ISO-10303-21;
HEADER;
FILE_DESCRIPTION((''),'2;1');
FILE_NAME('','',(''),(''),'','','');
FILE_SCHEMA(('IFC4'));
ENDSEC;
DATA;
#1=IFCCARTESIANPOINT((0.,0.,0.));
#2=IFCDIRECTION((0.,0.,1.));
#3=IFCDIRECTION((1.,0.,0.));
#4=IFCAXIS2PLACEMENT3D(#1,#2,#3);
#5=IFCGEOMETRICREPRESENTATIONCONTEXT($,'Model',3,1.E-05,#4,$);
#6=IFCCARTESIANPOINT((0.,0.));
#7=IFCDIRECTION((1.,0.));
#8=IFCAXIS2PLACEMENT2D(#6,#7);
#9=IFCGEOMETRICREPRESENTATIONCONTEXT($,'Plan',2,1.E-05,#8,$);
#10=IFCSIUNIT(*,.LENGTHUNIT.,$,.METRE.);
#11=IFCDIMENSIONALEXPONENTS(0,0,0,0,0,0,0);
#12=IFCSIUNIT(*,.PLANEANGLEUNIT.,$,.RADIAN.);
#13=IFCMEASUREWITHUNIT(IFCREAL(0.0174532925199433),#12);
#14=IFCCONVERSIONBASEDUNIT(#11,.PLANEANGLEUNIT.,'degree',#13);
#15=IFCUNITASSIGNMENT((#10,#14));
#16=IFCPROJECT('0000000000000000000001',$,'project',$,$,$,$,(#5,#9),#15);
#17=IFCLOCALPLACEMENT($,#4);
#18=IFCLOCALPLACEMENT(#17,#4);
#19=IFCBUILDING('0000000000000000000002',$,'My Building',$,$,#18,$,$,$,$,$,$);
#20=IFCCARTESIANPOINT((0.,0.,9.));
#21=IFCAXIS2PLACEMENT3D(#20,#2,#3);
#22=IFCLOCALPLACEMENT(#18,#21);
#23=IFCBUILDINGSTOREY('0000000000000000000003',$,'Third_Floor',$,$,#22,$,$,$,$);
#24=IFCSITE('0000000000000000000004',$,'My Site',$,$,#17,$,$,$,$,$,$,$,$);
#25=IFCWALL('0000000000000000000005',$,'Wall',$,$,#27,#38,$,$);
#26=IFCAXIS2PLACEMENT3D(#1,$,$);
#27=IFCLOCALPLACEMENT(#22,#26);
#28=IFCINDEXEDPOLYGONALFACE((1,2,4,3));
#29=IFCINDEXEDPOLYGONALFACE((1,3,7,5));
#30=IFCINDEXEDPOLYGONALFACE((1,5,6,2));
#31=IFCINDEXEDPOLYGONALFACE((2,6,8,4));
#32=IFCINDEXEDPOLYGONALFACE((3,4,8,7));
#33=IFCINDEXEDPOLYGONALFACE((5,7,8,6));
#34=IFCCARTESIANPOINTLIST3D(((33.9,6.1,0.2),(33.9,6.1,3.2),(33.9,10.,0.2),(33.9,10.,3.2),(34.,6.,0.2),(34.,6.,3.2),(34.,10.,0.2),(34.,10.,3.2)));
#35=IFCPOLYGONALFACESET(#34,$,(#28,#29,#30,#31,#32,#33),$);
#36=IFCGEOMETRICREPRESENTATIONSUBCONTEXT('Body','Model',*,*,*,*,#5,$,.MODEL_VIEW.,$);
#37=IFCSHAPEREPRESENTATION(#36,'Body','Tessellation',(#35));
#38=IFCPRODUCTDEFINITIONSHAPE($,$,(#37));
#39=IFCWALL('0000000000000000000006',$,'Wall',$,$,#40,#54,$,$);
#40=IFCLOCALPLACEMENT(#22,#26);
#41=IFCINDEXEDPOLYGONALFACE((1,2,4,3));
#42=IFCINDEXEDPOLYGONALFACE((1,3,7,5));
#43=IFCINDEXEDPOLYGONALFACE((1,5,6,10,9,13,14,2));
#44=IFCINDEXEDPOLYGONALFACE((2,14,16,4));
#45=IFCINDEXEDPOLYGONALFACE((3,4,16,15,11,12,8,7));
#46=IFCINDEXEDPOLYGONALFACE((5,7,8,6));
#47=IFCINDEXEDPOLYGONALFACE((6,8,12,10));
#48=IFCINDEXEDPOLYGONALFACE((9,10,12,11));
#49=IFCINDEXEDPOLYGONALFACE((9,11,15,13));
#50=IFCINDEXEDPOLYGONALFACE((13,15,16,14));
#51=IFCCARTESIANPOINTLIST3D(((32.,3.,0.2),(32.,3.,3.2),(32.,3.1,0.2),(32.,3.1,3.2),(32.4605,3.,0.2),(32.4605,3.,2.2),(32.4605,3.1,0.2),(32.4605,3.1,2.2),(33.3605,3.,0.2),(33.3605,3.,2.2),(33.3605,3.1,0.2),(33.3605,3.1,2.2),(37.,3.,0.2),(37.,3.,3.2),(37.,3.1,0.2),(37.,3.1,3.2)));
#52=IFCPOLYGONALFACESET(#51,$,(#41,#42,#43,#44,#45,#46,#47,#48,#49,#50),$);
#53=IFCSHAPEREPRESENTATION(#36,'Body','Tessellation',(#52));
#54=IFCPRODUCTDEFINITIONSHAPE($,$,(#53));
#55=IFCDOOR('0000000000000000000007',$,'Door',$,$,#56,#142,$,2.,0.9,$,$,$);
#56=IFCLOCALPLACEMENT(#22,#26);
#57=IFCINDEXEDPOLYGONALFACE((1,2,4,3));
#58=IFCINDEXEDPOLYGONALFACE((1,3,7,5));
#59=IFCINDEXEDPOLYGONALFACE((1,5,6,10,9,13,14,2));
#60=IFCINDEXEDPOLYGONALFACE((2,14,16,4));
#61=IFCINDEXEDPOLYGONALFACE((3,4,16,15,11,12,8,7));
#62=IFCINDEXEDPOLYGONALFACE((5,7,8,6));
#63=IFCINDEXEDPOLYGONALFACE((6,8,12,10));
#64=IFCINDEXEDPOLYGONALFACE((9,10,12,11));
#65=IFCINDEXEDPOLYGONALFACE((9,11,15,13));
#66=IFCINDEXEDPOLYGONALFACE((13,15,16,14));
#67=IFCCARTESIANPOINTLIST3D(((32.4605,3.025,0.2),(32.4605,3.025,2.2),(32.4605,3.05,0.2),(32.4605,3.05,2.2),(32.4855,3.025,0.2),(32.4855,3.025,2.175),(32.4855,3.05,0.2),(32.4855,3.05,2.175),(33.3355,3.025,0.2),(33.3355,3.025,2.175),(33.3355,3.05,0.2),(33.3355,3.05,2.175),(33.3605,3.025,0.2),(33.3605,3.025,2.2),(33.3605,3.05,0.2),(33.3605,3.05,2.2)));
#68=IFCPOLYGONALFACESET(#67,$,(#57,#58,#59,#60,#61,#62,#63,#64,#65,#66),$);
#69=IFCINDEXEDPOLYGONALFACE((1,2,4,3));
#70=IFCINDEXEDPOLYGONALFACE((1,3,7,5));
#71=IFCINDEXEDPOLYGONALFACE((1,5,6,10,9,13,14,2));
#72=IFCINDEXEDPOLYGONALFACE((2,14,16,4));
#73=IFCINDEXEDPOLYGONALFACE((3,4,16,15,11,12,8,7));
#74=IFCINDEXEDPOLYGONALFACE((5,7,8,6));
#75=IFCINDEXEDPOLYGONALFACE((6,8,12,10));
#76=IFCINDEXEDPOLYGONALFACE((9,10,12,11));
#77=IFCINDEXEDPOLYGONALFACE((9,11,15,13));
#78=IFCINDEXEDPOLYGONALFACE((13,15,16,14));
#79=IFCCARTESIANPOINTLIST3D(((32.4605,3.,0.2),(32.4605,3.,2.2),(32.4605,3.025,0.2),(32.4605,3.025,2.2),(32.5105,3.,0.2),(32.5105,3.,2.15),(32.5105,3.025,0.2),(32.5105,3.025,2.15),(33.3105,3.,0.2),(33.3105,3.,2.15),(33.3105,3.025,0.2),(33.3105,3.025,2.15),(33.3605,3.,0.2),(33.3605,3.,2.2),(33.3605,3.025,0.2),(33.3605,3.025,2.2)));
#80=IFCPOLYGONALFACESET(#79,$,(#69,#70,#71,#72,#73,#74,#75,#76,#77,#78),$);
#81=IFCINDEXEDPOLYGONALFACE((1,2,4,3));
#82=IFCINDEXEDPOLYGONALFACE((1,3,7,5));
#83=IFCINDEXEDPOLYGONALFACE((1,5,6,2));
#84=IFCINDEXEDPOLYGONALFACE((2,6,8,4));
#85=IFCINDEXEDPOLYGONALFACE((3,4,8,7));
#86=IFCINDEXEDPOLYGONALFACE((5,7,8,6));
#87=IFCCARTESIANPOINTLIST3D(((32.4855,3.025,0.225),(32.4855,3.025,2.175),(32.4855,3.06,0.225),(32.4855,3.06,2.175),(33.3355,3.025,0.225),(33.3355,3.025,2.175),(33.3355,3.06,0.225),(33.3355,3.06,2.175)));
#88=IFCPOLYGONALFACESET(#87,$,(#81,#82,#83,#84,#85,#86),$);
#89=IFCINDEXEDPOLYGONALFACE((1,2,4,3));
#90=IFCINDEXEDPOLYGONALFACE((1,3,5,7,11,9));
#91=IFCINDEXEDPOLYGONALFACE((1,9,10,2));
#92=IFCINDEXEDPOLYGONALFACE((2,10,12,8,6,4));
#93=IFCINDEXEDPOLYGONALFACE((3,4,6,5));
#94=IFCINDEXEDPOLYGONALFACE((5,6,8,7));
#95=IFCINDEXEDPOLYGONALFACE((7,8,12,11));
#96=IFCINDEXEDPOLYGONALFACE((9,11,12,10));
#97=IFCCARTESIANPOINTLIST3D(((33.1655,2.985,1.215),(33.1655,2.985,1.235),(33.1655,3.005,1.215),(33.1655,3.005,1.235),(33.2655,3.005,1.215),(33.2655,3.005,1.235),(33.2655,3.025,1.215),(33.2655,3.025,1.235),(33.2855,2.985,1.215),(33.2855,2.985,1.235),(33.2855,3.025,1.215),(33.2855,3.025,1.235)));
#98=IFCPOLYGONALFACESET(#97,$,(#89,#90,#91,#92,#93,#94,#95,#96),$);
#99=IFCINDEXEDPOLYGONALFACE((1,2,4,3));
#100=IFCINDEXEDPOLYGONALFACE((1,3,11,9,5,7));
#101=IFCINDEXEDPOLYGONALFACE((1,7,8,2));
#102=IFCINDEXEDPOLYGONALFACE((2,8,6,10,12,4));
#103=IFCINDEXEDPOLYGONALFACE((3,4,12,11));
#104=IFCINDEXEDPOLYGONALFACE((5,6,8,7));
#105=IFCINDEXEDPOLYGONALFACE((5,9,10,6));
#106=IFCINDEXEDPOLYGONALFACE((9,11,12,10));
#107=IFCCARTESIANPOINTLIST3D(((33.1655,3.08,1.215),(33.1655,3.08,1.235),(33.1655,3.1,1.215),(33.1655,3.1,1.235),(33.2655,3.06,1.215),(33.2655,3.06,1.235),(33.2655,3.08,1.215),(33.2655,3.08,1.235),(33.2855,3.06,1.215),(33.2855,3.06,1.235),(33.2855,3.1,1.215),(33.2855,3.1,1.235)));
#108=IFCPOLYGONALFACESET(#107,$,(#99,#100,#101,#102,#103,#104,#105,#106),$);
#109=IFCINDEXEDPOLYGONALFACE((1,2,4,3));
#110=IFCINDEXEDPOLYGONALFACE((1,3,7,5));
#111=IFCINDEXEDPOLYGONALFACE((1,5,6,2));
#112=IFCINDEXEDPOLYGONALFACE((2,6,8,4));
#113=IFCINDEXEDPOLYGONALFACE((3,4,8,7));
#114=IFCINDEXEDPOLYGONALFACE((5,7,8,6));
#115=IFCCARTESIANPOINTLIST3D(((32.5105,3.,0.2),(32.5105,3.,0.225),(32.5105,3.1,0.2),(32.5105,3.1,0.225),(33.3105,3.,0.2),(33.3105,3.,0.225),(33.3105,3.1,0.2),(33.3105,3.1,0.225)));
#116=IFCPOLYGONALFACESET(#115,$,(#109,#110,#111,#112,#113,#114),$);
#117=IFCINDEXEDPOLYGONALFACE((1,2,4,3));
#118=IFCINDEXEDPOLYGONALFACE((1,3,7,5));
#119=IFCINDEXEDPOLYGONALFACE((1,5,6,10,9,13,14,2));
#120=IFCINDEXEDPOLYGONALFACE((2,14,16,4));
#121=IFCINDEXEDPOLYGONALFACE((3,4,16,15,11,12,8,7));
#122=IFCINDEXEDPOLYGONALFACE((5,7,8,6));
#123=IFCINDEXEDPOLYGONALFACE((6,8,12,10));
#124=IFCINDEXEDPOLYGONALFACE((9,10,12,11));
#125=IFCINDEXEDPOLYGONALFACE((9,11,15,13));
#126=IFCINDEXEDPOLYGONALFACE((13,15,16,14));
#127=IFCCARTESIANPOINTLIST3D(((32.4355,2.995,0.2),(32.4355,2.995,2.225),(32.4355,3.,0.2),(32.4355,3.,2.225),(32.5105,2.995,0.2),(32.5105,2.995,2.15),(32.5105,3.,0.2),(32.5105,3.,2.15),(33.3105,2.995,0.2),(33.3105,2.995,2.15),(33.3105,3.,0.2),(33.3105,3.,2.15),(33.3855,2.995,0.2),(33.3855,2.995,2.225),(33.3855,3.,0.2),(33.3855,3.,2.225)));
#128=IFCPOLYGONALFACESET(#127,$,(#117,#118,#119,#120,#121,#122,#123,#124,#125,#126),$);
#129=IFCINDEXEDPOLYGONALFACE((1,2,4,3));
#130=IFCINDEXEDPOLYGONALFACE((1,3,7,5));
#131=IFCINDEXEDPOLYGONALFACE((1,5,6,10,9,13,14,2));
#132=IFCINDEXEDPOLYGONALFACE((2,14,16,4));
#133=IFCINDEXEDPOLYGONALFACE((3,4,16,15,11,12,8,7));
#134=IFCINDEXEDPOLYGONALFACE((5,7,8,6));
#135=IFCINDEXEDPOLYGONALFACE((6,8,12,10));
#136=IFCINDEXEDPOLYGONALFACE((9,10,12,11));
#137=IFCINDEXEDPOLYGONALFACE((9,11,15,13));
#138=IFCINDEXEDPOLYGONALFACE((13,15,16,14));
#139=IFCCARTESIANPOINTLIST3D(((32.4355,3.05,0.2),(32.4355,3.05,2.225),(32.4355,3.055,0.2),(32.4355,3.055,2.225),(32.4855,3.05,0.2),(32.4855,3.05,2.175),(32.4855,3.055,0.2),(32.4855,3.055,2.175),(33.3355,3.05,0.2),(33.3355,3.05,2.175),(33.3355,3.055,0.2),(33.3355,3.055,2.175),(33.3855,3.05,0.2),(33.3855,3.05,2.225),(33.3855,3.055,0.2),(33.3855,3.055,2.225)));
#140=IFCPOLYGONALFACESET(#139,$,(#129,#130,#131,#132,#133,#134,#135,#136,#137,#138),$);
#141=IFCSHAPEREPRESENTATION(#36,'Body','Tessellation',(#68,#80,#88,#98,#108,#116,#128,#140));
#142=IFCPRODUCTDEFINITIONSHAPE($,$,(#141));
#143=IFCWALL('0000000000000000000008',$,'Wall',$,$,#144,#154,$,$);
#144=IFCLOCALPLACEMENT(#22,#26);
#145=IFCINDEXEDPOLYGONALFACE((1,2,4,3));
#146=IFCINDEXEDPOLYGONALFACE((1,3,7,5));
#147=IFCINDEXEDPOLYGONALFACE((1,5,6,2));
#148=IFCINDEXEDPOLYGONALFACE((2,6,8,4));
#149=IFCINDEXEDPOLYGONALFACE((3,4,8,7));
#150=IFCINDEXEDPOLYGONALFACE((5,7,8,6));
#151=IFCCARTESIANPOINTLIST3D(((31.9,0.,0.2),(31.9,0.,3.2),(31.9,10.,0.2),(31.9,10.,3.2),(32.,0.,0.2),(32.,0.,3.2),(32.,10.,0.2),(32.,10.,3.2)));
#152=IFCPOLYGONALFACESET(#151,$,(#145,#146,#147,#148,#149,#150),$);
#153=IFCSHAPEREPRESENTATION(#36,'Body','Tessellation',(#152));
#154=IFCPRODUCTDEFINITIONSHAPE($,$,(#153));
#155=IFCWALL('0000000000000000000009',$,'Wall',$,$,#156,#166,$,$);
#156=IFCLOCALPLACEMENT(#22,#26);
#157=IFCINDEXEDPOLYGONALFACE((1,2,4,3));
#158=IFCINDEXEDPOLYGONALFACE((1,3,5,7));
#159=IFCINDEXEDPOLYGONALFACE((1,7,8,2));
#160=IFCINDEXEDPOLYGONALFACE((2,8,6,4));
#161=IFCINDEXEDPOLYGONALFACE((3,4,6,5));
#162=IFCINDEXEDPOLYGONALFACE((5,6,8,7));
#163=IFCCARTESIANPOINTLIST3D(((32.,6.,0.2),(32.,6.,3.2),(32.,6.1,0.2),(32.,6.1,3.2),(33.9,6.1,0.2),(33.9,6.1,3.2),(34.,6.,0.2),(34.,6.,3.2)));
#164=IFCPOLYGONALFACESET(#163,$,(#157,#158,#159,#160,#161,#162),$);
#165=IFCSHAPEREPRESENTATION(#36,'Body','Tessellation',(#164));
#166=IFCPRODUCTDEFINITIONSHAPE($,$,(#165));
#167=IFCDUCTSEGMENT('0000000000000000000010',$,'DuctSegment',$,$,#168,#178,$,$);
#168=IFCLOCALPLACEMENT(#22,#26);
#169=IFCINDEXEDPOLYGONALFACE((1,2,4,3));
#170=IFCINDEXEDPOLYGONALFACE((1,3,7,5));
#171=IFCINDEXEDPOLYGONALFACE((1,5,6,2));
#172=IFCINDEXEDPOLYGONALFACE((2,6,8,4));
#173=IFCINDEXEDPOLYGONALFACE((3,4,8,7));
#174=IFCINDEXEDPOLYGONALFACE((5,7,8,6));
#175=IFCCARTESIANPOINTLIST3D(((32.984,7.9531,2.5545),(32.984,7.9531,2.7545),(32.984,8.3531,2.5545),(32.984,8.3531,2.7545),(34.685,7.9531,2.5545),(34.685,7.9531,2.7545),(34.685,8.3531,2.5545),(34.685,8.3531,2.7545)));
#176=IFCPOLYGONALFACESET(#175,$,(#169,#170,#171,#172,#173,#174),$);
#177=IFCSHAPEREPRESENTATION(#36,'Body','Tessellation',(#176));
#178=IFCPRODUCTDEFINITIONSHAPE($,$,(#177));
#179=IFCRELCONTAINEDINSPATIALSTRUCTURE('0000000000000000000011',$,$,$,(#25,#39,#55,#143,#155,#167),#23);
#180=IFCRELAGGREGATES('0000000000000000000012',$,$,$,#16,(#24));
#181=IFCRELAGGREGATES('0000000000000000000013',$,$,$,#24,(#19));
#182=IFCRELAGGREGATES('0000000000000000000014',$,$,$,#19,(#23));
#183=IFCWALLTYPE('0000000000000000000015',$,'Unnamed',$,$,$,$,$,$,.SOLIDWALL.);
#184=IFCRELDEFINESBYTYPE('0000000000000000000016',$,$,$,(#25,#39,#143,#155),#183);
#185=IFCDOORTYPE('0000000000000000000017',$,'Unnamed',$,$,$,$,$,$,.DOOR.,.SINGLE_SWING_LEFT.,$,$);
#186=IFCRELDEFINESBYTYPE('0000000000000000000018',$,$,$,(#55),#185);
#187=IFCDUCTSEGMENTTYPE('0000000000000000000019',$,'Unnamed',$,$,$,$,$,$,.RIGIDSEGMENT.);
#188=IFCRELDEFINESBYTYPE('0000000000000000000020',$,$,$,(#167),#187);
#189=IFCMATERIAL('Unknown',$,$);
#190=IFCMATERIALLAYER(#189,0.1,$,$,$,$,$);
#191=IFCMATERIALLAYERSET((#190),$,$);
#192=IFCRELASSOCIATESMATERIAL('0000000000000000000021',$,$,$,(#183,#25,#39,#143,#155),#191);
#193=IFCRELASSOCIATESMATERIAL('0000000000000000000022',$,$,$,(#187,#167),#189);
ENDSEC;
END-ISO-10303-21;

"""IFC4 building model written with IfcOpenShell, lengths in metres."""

from ifc_helpers import new_model, entity, si_unit, converted_unit, frame, origin_with_axes, origin_2d_with_axis, place, context, subcontext, project, spatial, line, indexed_curve, rectangle, outline, extrude, shape, source, transform, mapped, material, layer, layer_set, layer_usage, material_profile, profile_set, profile_usage, type_object, type_shapes, element, fill, save


model = new_model("IFC4")

# Units and contexts
model_context = context("Model", 3, precision=1e-05, world=origin_with_axes())
plan_context = context("Plan", 2, precision=1e-05, world=origin_2d_with_axis())
body_context_1 = subcontext(model_context, "Body", "Model", "MODEL_VIEW")
body_context_2 = subcontext(plan_context, "Body", "Plan", "PLAN_VIEW")
ifc_project = project(units=[si_unit("LENGTHUNIT", "METRE"), converted_unit("PLANEANGLEUNIT", "degree", entity("IfcReal", 0.0174532925199433), si_unit("PLANEANGLEUNIT", "RADIAN"), dimensions=[0, 0, 0, 0, 0, 0, 0])], contexts=[model_context, plan_context])

# Site, building, storey
site_placement = place(None, origin_with_axes())
site = spatial("IfcSite", under=ifc_project, at=site_placement, Name="My Site")
building_placement = place(site_placement, origin_with_axes())
building = spatial("IfcBuilding", under=site, at=building_placement, Name="My Building")
storey_placement = place(building_placement, frame((0.0, 0.0, 9.0), z_axis=(0.0, 0.0, 1.0), x_axis=(1.0, 0.0, 0.0)))
storey = spatial("IfcBuildingStorey", under=building, at=storey_placement, Name="Third_Floor")

# Wall
ifc_material = material(Name="Unknown")
ifc_layer = layer(ifc_material, 0.1)
ifc_layer_set = layer_set([ifc_layer])
ifc_layer_usage_1 = layer_usage(ifc_layer_set, "AXIS2", "POSITIVE", 0.0)
wall_type = type_object("IfcWallType", Name="Unnamed", PredefinedType="SOLIDWALL", material=ifc_layer_set)
wall_1_placement = place(storey_placement, frame((34.0, 6.0, 0.2), z_axis=(0.0, 0.0, 1.0), x_axis=(0.0, 1.0, 0.0)))
element("IfcWall", 1, at=wall_1_placement, inside=storey, type_object=wall_type, material=ifc_layer_usage_1, Name="Wall", context=body_context_1, shape_type="SweptSolid", body=[
    extrude(outline(indexed_curve([(0.0, 0.0), (0.1, 0.1), (4.0, 0.1), (4.0, 0.0)], segments=[line(1, 2, 3, 4, 1)])), origin_with_axes(), (0.0, 0.0, 1.0), 3.0),
])

# Wall, opening, door
ifc_layer_usage_2 = layer_usage(ifc_layer_set, "AXIS2", "POSITIVE", 0.0)
wall_2_placement = place(storey_placement, frame((32.0, 3.0, 0.2), z_axis=(0.0, 0.0, 1.0), x_axis=(1.0, 0.0, 0.0)))
wall_2 = element("IfcWall", 2, at=wall_2_placement, inside=storey, type_object=wall_type, material=ifc_layer_usage_2, Name="Wall", context=body_context_1, shape_type="SweptSolid", body=[
    extrude(outline(indexed_curve([(0.0, 0.0), (0.0, 0.1), (5.0, 0.1), (5.0, 0.0)], segments=[line(1, 2, 3, 4, 1)])), origin_with_axes(), (0.0, 0.0, 1.0), 3.0),
])
shared_shape_1 = source(origin_with_axes(), body_context_1, "Body", "SweptSolid", [
    extrude(outline(indexed_curve([(0.0, 0.0), (0.9, 0.0), (0.9, 2.0), (0.0, 2.0)], segments=[line(1, 2, 3, 4, 1)])), frame((0.0, -0.6, 0.0), z_axis=(0.0, -1.0, 0.0), x_axis=(1.0, 0.0, 0.0)), (0.0, 0.0, -1.0), 1.2),
])
opening_placement = place(wall_2_placement, frame((0.4605, 0.0, 0.0), z_axis=(0.0, 0.0, 1.0), x_axis=(1.0, 0.0, 0.0)))
opening = element("IfcOpeningElement", 3, at=opening_placement, cuts=wall_2, PredefinedType="OPENING", context=body_context_1, shape_type="MappedRepresentation", body=[
    mapped(shared_shape_1, transform((0.0, 0.0, 0.0), x_axis=(1.0, 0.0, 0.0), y_axis=(0.0, 1.0, 0.0), z_axis=(0.0, 0.0, 1.0), scale=1.0)),
])
door_type = type_object("IfcDoorType", Name="Unnamed", OperationType="SINGLE_SWING_LEFT", PredefinedType="DOOR")
shared_shape_2 = source(origin_with_axes(), body_context_1, "Body", "SweptSolid", [
    extrude(outline(indexed_curve([(0.0, 0.0), (0.0, 2.0), (0.9, 2.0), (0.9, 0.0), (0.875, 0.0), (0.875, 1.975), (0.025, 1.975), (0.025, 0.0)], segments=[line(1, 2, 3, 4, 5, 6, 7, 8, 1)])), frame((0.0, 0.025, 0.0), z_axis=(0.0, -1.0, 0.0), x_axis=(1.0, 0.0, 0.0)), (0.0, 0.0, -1.0), 0.025),
    extrude(outline(indexed_curve([(0.0, 0.0), (0.0, 2.0), (0.9, 2.0), (0.9, 0.0), (0.85, 0.0), (0.85, 1.95), (0.05, 1.95), (0.05, 0.0)], segments=[line(1, 2, 3, 4, 5, 6, 7, 8, 1)])), frame((0.0, 0.0, 0.0), z_axis=(0.0, -1.0, 0.0), x_axis=(1.0, 0.0, 0.0)), (0.0, 0.0, -1.0), 0.025),
    extrude(outline(indexed_curve([(0.0, 0.0), (0.85, 0.0), (0.85, 0.035), (0.0, 0.035)], segments=[line(1, 2, 3, 4, 1)])), frame((0.025, 0.025, 0.025), z_axis=(0.0, 0.0, 1.0), x_axis=(1.0, 0.0, 0.0)), (0.0, 0.0, 1.0), 1.95),
    extrude(outline(indexed_curve([(0.0, 0.0), (0.0, -0.04), (-0.12, -0.04), (-0.12, -0.02), (-0.02, -0.02), (-0.02, 0.0)], segments=[line(1, 2, 3, 4, 5, 6, 1)])), frame((0.825, 0.025, 1.015), z_axis=(0.0, 0.0, 1.0), x_axis=(1.0, 0.0, 0.0)), (0.0, 0.0, 1.0), 0.02),
    extrude(outline(indexed_curve([(0.0, 0.0), (0.0, 0.04), (-0.12, 0.04), (-0.12, 0.02), (-0.02, 0.02), (-0.02, 0.0)], segments=[line(1, 2, 3, 4, 5, 6, 1)])), frame((0.825, 0.06, 1.015), z_axis=(0.0, 0.0, 1.0), x_axis=(1.0, 0.0, 0.0)), (0.0, 0.0, 1.0), 0.02),
    extrude(outline(indexed_curve([(0.0, 0.0), (0.8, 0.0), (0.8, 0.1), (0.0, 0.1)], segments=[line(1, 2, 3, 4, 1)])), frame((0.05, 0.0, 0.0), z_axis=(0.0, 0.0, 1.0), x_axis=(1.0, 0.0, 0.0)), (0.0, 0.0, 1.0), 0.025),
    extrude(outline(indexed_curve([(0.0, 0.0), (0.0, 2.025), (0.95, 2.025), (0.95, 0.0), (0.875, 0.0), (0.875, 1.95), (0.075, 1.95), (0.075, 0.0)], segments=[line(1, 2, 3, 4, 5, 6, 7, 8, 1)])), frame((-0.025, -0.005, 0.0), z_axis=(0.0, -1.0, 0.0), x_axis=(1.0, 0.0, 0.0)), (0.0, 0.0, -1.0), 0.005),
    extrude(outline(indexed_curve([(0.0, 0.0), (0.0, 2.025), (0.95, 2.025), (0.95, 0.0), (0.9, 0.0), (0.9, 1.975), (0.05, 1.975), (0.05, 0.0)], segments=[line(1, 2, 3, 4, 5, 6, 7, 8, 1)])), frame((-0.025, 0.05, 0.0), z_axis=(0.0, -1.0, 0.0), x_axis=(1.0, 0.0, 0.0)), (0.0, 0.0, -1.0), 0.005),
])
shared_shape_3 = source(origin_with_axes(), body_context_2, "Body", "Curve2D", [
    entity("IfcIndexedPolyCurve", entity("IfcCartesianPointList2D", [[0.0, 0.0], [0.0, 0.05], [0.025, 0.05], [0.025, 0.025], [0.05, 0.025], [0.05, 0.0]]), [entity("IfcLineIndex", [1, 2, 3, 4, 5, 6, 1])]),
    entity("IfcIndexedPolyCurve", entity("IfcCartesianPointList2D", [[0.9, 0.0], [0.9, 0.05], [0.875, 0.05], [0.875, 0.025], [0.85, 0.025], [0.85, 0.0]]), [entity("IfcLineIndex", [1, 2, 3, 4, 5, 6, 1])]),
    entity("IfcTrimmedCurve", entity("IfcEllipse", entity("IfcAxis2Placement2D", entity("IfcCartesianPoint", [0.06, 0.05]), entity("IfcDirection", [1.0, 0.0])), 0.815, 0.85), [entity("IfcCartesianPoint", [0.875, 0.05])], [entity("IfcCartesianPoint", [0.06, 0.9])], True, "CARTESIAN"),
    entity("IfcIndexedPolyCurve", entity("IfcCartesianPointList2D", [[0.025, 0.05], [0.06, 0.05], [0.06, 0.9], [0.025, 0.9]]), [entity("IfcLineIndex", [1, 2, 3, 4, 1])]),
])
type_shapes(door_type, [shared_shape_2, shared_shape_3])
door_placement = place(opening_placement, origin_with_axes())
door = element("IfcDoor", 4, at=door_placement, inside=storey, type_object=door_type, Name="Door", OverallHeight=2.0, OverallWidth=0.9, shapes=[
    shape(body_context_1, "Body", "MappedRepresentation", [mapped(shared_shape_2, transform((0.0, 0.0, 0.0), x_axis=(1.0, 0.0, 0.0), y_axis=(0.0, 1.0, 0.0), z_axis=(0.0, 0.0, 1.0), scale=1.0))]),
    shape(body_context_2, "Body", "MappedRepresentation", [mapped(shared_shape_3, transform((0.0, 0.0, 0.0), x_axis=(1.0, 0.0, 0.0), y_axis=(0.0, 1.0, 0.0), z_axis=(0.0, 0.0, 1.0), scale=1.0))]),
])
fill(opening, door)

# Walls
ifc_layer_usage_3 = layer_usage(ifc_layer_set, "AXIS2", "POSITIVE", 0.0)
wall_3_placement = place(storey_placement, frame((31.9, 10.0, 0.2), z_axis=(0.0, 0.0, 1.0), x_axis=(0.0, -1.0, 0.0)))
element("IfcWall", 5, at=wall_3_placement, inside=storey, type_object=wall_type, material=ifc_layer_usage_3, Name="Wall", context=body_context_1, shape_type="SweptSolid", body=[
    extrude(outline(indexed_curve([(0.0, 0.0), (0.0, 0.1), (10.0, 0.1), (10.0, 0.0)], segments=[line(1, 2, 3, 4, 1)])), origin_with_axes(), (0.0, 0.0, 1.0), 3.0),
])
ifc_layer_usage_4 = layer_usage(ifc_layer_set, "AXIS2", "POSITIVE", 0.0)
wall_4_placement = place(storey_placement, frame((32.0, 6.0, 0.2), z_axis=(0.0, 0.0, 1.0), x_axis=(1.0, 0.0, 0.0)))
element("IfcWall", 6, at=wall_4_placement, inside=storey, type_object=wall_type, material=ifc_layer_usage_4, Name="Wall", context=body_context_1, shape_type="SweptSolid", body=[
    extrude(outline(indexed_curve([(0.0, 0.0), (0.0, 0.1), (1.9, 0.1), (2.0, 0.0)], segments=[line(1, 2, 3, 4, 1)])), origin_with_axes(), (0.0, 0.0, 1.0), 3.0),
])

# Duct segment
ifc_material_profile_1 = material_profile(ifc_material, rectangle(XDim=0.4, YDim=0.2))
ifc_profile_set_1 = profile_set([ifc_material_profile_1])
ifc_profile_usage_1 = profile_usage(ifc_profile_set_1, cardinal=5)
duct_segment_type = type_object("IfcDuctSegmentType", Name="Unnamed", PredefinedType="RIGIDSEGMENT", material=ifc_profile_set_1)
duct_segment_1_placement = place(storey_placement, frame((34.685, 8.1531, 2.6545), z_axis=(-1.0, 0.000001, 0.000001), x_axis=(-0.000001, -1.0, 0.0)))
element("IfcDuctSegment", 7, at=duct_segment_1_placement, inside=storey, type_object=duct_segment_type, material=ifc_profile_usage_1, Name="DuctSegment", context=body_context_1, shape_type="SweptSolid", body=[
    extrude(rectangle(XDim=0.4, YDim=0.2), origin_with_axes(), (0.0, 0.0, 1.0), 1.701),
])

save(model, "model.ifc")
